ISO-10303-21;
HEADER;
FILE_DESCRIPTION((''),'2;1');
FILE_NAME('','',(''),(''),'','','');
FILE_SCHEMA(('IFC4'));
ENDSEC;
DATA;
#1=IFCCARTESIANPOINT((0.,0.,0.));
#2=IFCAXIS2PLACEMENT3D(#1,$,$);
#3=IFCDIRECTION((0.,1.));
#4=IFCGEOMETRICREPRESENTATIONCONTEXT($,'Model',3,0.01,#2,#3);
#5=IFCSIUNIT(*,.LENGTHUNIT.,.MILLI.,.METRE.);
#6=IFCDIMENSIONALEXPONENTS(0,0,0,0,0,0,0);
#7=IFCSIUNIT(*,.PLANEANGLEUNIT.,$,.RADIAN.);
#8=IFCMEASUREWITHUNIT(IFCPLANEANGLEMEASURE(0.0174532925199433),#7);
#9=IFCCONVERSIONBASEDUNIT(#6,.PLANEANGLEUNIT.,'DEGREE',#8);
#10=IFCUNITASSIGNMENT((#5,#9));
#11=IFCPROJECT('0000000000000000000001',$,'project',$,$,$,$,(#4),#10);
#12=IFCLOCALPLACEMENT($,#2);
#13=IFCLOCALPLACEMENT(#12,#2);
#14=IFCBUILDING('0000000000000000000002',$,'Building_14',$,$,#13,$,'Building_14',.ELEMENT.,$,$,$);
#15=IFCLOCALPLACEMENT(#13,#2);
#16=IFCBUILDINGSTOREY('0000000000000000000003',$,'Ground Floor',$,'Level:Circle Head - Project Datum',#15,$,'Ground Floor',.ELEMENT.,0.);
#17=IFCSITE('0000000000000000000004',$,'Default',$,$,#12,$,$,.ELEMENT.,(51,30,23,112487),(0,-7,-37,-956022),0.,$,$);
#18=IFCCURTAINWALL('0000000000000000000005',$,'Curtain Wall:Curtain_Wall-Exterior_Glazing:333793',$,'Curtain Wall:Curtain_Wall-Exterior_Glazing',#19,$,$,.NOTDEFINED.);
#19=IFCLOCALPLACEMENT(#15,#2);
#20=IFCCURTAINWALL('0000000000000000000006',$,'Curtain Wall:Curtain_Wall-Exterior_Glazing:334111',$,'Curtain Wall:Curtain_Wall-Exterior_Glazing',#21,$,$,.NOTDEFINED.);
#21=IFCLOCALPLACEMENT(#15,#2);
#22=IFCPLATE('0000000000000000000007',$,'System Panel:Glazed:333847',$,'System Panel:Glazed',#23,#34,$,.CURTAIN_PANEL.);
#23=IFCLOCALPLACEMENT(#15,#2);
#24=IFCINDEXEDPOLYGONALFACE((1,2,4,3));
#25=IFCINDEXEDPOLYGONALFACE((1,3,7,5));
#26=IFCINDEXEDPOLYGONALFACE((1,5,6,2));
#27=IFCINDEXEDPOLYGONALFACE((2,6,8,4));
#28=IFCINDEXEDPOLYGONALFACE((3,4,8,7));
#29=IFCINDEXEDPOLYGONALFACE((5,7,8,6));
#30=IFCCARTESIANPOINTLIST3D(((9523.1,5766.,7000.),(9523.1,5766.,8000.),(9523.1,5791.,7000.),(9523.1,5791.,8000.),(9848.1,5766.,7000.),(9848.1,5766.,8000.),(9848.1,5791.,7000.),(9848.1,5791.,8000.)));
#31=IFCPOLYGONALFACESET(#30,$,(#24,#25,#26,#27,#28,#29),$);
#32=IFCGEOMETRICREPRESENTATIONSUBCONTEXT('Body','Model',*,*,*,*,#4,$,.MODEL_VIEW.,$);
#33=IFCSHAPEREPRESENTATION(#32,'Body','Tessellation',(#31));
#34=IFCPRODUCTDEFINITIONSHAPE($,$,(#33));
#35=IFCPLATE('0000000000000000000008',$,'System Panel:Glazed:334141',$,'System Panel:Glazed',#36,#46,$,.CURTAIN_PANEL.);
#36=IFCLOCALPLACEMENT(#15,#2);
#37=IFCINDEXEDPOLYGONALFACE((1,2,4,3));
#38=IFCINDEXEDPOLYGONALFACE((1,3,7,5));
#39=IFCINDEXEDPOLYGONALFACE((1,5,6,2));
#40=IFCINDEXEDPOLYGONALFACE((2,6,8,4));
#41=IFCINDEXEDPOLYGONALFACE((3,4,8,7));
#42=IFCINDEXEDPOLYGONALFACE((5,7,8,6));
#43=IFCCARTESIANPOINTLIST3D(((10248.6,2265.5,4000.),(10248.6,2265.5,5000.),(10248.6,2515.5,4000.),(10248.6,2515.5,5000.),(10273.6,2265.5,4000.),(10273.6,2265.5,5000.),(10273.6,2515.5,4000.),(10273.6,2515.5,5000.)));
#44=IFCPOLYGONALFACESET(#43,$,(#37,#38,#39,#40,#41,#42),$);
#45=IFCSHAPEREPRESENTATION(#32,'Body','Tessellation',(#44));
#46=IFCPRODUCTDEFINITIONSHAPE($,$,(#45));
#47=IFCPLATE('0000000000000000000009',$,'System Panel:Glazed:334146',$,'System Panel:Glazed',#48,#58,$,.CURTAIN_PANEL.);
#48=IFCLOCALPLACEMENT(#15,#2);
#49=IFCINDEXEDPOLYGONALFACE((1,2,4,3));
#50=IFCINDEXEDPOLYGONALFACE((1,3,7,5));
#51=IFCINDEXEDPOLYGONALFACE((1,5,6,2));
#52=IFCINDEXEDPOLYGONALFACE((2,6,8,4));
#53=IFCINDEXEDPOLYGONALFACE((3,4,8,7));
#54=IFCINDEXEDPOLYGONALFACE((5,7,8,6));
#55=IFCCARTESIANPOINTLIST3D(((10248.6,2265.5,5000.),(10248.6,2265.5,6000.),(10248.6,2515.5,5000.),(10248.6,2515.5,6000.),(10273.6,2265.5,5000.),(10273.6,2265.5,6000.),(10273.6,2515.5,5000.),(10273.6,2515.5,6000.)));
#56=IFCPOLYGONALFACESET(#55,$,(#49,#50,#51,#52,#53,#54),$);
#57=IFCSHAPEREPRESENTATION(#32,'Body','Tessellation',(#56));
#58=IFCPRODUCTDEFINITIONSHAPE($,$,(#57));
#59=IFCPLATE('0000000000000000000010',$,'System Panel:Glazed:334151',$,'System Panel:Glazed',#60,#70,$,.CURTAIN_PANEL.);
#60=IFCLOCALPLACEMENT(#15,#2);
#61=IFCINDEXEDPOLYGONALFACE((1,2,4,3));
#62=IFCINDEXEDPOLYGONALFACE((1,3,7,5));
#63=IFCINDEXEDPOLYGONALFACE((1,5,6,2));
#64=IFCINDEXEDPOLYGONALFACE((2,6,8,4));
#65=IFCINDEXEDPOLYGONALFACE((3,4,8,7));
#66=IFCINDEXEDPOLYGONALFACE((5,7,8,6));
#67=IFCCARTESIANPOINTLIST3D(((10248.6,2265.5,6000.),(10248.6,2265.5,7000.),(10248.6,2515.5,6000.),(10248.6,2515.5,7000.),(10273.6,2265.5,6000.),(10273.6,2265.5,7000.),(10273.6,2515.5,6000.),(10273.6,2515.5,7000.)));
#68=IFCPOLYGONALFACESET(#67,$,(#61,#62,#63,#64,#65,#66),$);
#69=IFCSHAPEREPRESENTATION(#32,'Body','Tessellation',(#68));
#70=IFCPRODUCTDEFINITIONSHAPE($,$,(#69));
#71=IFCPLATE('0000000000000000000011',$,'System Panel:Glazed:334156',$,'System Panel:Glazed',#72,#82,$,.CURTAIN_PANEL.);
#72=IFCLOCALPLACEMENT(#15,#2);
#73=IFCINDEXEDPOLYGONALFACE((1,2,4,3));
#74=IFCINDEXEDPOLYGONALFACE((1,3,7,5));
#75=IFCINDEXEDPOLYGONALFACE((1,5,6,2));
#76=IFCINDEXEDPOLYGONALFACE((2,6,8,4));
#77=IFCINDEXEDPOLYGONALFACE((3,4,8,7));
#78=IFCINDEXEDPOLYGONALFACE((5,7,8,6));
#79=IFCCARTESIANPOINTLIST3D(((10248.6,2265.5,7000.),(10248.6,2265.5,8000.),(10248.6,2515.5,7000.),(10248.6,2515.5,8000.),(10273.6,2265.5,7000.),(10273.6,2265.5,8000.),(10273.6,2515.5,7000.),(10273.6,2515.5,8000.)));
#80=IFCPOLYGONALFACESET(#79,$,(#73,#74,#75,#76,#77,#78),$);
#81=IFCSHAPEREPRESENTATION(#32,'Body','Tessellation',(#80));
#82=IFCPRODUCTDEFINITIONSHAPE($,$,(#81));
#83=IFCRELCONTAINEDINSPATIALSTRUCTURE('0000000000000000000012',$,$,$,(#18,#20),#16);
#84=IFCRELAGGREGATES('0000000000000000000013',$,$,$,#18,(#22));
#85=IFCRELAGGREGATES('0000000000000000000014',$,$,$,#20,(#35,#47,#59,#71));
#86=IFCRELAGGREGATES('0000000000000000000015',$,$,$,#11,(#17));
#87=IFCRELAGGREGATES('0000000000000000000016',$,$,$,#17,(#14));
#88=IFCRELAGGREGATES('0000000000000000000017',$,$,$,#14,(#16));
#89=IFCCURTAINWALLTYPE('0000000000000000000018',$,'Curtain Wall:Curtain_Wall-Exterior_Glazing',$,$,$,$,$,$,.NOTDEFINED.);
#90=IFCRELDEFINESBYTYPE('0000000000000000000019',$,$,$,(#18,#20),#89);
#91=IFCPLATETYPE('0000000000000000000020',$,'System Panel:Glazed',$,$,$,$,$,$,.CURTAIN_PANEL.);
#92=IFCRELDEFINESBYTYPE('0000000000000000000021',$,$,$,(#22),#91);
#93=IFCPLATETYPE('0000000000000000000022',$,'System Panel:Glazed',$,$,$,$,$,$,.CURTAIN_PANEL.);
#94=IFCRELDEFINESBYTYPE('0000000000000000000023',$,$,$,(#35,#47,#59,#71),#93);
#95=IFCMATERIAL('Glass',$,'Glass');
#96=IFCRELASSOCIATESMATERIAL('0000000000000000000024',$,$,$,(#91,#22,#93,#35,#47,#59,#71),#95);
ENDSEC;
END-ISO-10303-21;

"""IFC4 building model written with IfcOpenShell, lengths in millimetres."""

from ifc_helpers import new_model, entity, si_unit, converted_unit, direction, frame, origin, place, context, subcontext, project, spatial, indexed_curve, outline, extrude, source, transform, mapped, material, type_object, type_shapes, element, aggregate, save


model = new_model("IFC4")

# Units and contexts
model_context = context("Model", 3, precision=0.01, world=origin(), true_north=direction((0.0, 1.0)))
body_context = subcontext(model_context, "Body", "Model", "MODEL_VIEW")
ifc_project = project(units=[si_unit("LENGTHUNIT", "METRE", prefix="MILLI"), converted_unit("PLANEANGLEUNIT", "DEGREE", entity("IfcPlaneAngleMeasure", 0.0174532925199433), si_unit("PLANEANGLEUNIT", "RADIAN"), dimensions=[0, 0, 0, 0, 0, 0, 0])], contexts=[model_context])

# Site, building, storey
site_placement = place(None, origin())
site = spatial("IfcSite", under=ifc_project, at=site_placement, Name="Default", CompositionType="ELEMENT", RefLatitude=(51, 30, 23, 112487), RefLongitude=(0, -7, -37, -956022), RefElevation=0.0)
building_placement = place(site_placement, origin())
building = spatial("IfcBuilding", under=site, at=building_placement, Name="Building_14", LongName="Building_14", CompositionType="ELEMENT")
storey_placement = place(building_placement, origin())
storey = spatial("IfcBuildingStorey", under=building, at=storey_placement, Name="Ground Floor", ObjectType="Level:Circle Head - Project Datum", LongName="Ground Floor", CompositionType="ELEMENT", Elevation=0.0)

# Curtain walls
curtain_wall_type = type_object("IfcCurtainWallType", Name="Curtain Wall:Curtain_Wall-Exterior_Glazing", PredefinedType="NOTDEFINED")
curtain_wall_1_placement = place(storey_placement, origin())
curtain_wall_1 = element("IfcCurtainWall", 1, at=curtain_wall_1_placement, inside=storey, type_object=curtain_wall_type, Name="Curtain Wall:Curtain_Wall-Exterior_Glazing:333793", ObjectType="Curtain Wall:Curtain_Wall-Exterior_Glazing", PredefinedType="NOTDEFINED")
ifc_material = material(Name="Glass", Category="Glass")
curtain_wall_2_placement = place(storey_placement, origin())
curtain_wall_2 = element("IfcCurtainWall", 2, at=curtain_wall_2_placement, inside=storey, type_object=curtain_wall_type, Name="Curtain Wall:Curtain_Wall-Exterior_Glazing:334111", ObjectType="Curtain Wall:Curtain_Wall-Exterior_Glazing", PredefinedType="NOTDEFINED")

# Plates
plate_type_1 = type_object("IfcPlateType", Name="System Panel:Glazed", PredefinedType="CURTAIN_PANEL", material=ifc_material)
shared_shape_1 = source(origin(), body_context, "Body", "SweptSolid", [
    extrude(outline(indexed_curve([(-12.5, -162.5), (12.5, -162.5), (12.5, 162.5), (-12.5, 162.5), (-12.5, -162.5)], self_intersect=False)), frame((0.0, -37.0, 0.0), z_axis=(0.0, 0.0, 1.0), x_axis=(0.0, 1.0, 0.0)), (0.0, 0.0, 1.0), 1000.0),
])
type_shapes(plate_type_1, [shared_shape_1])
plate_1_placement = place(curtain_wall_1_placement, frame((9685.6, 5815.5, 7000.0)))
plate_1 = element("IfcPlate", 3, at=plate_1_placement, type_object=plate_type_1, material=ifc_material, Name="System Panel:Glazed:333847", ObjectType="System Panel:Glazed", PredefinedType="CURTAIN_PANEL", context=body_context, shape_type="MappedRepresentation", body=[
    mapped(shared_shape_1, transform((0.0, 0.0, 0.0), scale=1.0)),
])
aggregate(curtain_wall_1, [plate_1])
plate_type_2 = type_object("IfcPlateType", Name="System Panel:Glazed", PredefinedType="CURTAIN_PANEL", material=ifc_material)
shared_shape_2 = source(origin(), body_context, "Body", "SweptSolid", [
    extrude(outline(indexed_curve([(-12.5, -125.0), (12.5, -125.0), (12.5, 125.0), (-12.5, 125.0), (-12.5, -125.0)], self_intersect=False)), frame((0.0, -37.0, 0.0), z_axis=(0.0, 0.0, 1.0), x_axis=(0.0, 1.0, 0.0)), (0.0, 0.0, 1.0), 1000.0),
])
type_shapes(plate_type_2, [shared_shape_2])
plate_2_placement = place(curtain_wall_2_placement, frame((10298.1, 2390.5, 4000.0), z_axis=(0.0, 0.0, 1.0), x_axis=(0.0, -1.0, 0.0)))
plate_2 = element("IfcPlate", 4, at=plate_2_placement, type_object=plate_type_2, material=ifc_material, Name="System Panel:Glazed:334141", ObjectType="System Panel:Glazed", PredefinedType="CURTAIN_PANEL", context=body_context, shape_type="MappedRepresentation", body=[
    mapped(shared_shape_2, transform((0.0, 0.0, 0.0), scale=1.0)),
])
plate_3_placement = place(curtain_wall_2_placement, frame((10298.1, 2390.5, 5000.0), z_axis=(0.0, 0.0, 1.0), x_axis=(0.0, -1.0, 0.0)))
plate_3 = element("IfcPlate", 5, at=plate_3_placement, type_object=plate_type_2, material=ifc_material, Name="System Panel:Glazed:334146", ObjectType="System Panel:Glazed", PredefinedType="CURTAIN_PANEL", context=body_context, shape_type="MappedRepresentation", body=[
    mapped(shared_shape_2, transform((0.0, 0.0, 0.0), scale=1.0)),
])
plate_4_placement = place(curtain_wall_2_placement, frame((10298.1, 2390.5, 6000.0), z_axis=(0.0, 0.0, 1.0), x_axis=(0.0, -1.0, 0.0)))
plate_4 = element("IfcPlate", 6, at=plate_4_placement, type_object=plate_type_2, material=ifc_material, Name="System Panel:Glazed:334151", ObjectType="System Panel:Glazed", PredefinedType="CURTAIN_PANEL", context=body_context, shape_type="MappedRepresentation", body=[
    mapped(shared_shape_2, transform((0.0, 0.0, 0.0), scale=1.0)),
])
plate_5_placement = place(curtain_wall_2_placement, frame((10298.1, 2390.5, 7000.0), z_axis=(0.0, 0.0, 1.0), x_axis=(0.0, -1.0, 0.0)))
plate_5 = element("IfcPlate", 7, at=plate_5_placement, type_object=plate_type_2, material=ifc_material, Name="System Panel:Glazed:334156", ObjectType="System Panel:Glazed", PredefinedType="CURTAIN_PANEL", context=body_context, shape_type="MappedRepresentation", body=[
    mapped(shared_shape_2, transform((0.0, 0.0, 0.0), scale=1.0)),
])
aggregate(curtain_wall_2, [plate_2, plate_3, plate_4, plate_5])

save(model, "model.ifc")
